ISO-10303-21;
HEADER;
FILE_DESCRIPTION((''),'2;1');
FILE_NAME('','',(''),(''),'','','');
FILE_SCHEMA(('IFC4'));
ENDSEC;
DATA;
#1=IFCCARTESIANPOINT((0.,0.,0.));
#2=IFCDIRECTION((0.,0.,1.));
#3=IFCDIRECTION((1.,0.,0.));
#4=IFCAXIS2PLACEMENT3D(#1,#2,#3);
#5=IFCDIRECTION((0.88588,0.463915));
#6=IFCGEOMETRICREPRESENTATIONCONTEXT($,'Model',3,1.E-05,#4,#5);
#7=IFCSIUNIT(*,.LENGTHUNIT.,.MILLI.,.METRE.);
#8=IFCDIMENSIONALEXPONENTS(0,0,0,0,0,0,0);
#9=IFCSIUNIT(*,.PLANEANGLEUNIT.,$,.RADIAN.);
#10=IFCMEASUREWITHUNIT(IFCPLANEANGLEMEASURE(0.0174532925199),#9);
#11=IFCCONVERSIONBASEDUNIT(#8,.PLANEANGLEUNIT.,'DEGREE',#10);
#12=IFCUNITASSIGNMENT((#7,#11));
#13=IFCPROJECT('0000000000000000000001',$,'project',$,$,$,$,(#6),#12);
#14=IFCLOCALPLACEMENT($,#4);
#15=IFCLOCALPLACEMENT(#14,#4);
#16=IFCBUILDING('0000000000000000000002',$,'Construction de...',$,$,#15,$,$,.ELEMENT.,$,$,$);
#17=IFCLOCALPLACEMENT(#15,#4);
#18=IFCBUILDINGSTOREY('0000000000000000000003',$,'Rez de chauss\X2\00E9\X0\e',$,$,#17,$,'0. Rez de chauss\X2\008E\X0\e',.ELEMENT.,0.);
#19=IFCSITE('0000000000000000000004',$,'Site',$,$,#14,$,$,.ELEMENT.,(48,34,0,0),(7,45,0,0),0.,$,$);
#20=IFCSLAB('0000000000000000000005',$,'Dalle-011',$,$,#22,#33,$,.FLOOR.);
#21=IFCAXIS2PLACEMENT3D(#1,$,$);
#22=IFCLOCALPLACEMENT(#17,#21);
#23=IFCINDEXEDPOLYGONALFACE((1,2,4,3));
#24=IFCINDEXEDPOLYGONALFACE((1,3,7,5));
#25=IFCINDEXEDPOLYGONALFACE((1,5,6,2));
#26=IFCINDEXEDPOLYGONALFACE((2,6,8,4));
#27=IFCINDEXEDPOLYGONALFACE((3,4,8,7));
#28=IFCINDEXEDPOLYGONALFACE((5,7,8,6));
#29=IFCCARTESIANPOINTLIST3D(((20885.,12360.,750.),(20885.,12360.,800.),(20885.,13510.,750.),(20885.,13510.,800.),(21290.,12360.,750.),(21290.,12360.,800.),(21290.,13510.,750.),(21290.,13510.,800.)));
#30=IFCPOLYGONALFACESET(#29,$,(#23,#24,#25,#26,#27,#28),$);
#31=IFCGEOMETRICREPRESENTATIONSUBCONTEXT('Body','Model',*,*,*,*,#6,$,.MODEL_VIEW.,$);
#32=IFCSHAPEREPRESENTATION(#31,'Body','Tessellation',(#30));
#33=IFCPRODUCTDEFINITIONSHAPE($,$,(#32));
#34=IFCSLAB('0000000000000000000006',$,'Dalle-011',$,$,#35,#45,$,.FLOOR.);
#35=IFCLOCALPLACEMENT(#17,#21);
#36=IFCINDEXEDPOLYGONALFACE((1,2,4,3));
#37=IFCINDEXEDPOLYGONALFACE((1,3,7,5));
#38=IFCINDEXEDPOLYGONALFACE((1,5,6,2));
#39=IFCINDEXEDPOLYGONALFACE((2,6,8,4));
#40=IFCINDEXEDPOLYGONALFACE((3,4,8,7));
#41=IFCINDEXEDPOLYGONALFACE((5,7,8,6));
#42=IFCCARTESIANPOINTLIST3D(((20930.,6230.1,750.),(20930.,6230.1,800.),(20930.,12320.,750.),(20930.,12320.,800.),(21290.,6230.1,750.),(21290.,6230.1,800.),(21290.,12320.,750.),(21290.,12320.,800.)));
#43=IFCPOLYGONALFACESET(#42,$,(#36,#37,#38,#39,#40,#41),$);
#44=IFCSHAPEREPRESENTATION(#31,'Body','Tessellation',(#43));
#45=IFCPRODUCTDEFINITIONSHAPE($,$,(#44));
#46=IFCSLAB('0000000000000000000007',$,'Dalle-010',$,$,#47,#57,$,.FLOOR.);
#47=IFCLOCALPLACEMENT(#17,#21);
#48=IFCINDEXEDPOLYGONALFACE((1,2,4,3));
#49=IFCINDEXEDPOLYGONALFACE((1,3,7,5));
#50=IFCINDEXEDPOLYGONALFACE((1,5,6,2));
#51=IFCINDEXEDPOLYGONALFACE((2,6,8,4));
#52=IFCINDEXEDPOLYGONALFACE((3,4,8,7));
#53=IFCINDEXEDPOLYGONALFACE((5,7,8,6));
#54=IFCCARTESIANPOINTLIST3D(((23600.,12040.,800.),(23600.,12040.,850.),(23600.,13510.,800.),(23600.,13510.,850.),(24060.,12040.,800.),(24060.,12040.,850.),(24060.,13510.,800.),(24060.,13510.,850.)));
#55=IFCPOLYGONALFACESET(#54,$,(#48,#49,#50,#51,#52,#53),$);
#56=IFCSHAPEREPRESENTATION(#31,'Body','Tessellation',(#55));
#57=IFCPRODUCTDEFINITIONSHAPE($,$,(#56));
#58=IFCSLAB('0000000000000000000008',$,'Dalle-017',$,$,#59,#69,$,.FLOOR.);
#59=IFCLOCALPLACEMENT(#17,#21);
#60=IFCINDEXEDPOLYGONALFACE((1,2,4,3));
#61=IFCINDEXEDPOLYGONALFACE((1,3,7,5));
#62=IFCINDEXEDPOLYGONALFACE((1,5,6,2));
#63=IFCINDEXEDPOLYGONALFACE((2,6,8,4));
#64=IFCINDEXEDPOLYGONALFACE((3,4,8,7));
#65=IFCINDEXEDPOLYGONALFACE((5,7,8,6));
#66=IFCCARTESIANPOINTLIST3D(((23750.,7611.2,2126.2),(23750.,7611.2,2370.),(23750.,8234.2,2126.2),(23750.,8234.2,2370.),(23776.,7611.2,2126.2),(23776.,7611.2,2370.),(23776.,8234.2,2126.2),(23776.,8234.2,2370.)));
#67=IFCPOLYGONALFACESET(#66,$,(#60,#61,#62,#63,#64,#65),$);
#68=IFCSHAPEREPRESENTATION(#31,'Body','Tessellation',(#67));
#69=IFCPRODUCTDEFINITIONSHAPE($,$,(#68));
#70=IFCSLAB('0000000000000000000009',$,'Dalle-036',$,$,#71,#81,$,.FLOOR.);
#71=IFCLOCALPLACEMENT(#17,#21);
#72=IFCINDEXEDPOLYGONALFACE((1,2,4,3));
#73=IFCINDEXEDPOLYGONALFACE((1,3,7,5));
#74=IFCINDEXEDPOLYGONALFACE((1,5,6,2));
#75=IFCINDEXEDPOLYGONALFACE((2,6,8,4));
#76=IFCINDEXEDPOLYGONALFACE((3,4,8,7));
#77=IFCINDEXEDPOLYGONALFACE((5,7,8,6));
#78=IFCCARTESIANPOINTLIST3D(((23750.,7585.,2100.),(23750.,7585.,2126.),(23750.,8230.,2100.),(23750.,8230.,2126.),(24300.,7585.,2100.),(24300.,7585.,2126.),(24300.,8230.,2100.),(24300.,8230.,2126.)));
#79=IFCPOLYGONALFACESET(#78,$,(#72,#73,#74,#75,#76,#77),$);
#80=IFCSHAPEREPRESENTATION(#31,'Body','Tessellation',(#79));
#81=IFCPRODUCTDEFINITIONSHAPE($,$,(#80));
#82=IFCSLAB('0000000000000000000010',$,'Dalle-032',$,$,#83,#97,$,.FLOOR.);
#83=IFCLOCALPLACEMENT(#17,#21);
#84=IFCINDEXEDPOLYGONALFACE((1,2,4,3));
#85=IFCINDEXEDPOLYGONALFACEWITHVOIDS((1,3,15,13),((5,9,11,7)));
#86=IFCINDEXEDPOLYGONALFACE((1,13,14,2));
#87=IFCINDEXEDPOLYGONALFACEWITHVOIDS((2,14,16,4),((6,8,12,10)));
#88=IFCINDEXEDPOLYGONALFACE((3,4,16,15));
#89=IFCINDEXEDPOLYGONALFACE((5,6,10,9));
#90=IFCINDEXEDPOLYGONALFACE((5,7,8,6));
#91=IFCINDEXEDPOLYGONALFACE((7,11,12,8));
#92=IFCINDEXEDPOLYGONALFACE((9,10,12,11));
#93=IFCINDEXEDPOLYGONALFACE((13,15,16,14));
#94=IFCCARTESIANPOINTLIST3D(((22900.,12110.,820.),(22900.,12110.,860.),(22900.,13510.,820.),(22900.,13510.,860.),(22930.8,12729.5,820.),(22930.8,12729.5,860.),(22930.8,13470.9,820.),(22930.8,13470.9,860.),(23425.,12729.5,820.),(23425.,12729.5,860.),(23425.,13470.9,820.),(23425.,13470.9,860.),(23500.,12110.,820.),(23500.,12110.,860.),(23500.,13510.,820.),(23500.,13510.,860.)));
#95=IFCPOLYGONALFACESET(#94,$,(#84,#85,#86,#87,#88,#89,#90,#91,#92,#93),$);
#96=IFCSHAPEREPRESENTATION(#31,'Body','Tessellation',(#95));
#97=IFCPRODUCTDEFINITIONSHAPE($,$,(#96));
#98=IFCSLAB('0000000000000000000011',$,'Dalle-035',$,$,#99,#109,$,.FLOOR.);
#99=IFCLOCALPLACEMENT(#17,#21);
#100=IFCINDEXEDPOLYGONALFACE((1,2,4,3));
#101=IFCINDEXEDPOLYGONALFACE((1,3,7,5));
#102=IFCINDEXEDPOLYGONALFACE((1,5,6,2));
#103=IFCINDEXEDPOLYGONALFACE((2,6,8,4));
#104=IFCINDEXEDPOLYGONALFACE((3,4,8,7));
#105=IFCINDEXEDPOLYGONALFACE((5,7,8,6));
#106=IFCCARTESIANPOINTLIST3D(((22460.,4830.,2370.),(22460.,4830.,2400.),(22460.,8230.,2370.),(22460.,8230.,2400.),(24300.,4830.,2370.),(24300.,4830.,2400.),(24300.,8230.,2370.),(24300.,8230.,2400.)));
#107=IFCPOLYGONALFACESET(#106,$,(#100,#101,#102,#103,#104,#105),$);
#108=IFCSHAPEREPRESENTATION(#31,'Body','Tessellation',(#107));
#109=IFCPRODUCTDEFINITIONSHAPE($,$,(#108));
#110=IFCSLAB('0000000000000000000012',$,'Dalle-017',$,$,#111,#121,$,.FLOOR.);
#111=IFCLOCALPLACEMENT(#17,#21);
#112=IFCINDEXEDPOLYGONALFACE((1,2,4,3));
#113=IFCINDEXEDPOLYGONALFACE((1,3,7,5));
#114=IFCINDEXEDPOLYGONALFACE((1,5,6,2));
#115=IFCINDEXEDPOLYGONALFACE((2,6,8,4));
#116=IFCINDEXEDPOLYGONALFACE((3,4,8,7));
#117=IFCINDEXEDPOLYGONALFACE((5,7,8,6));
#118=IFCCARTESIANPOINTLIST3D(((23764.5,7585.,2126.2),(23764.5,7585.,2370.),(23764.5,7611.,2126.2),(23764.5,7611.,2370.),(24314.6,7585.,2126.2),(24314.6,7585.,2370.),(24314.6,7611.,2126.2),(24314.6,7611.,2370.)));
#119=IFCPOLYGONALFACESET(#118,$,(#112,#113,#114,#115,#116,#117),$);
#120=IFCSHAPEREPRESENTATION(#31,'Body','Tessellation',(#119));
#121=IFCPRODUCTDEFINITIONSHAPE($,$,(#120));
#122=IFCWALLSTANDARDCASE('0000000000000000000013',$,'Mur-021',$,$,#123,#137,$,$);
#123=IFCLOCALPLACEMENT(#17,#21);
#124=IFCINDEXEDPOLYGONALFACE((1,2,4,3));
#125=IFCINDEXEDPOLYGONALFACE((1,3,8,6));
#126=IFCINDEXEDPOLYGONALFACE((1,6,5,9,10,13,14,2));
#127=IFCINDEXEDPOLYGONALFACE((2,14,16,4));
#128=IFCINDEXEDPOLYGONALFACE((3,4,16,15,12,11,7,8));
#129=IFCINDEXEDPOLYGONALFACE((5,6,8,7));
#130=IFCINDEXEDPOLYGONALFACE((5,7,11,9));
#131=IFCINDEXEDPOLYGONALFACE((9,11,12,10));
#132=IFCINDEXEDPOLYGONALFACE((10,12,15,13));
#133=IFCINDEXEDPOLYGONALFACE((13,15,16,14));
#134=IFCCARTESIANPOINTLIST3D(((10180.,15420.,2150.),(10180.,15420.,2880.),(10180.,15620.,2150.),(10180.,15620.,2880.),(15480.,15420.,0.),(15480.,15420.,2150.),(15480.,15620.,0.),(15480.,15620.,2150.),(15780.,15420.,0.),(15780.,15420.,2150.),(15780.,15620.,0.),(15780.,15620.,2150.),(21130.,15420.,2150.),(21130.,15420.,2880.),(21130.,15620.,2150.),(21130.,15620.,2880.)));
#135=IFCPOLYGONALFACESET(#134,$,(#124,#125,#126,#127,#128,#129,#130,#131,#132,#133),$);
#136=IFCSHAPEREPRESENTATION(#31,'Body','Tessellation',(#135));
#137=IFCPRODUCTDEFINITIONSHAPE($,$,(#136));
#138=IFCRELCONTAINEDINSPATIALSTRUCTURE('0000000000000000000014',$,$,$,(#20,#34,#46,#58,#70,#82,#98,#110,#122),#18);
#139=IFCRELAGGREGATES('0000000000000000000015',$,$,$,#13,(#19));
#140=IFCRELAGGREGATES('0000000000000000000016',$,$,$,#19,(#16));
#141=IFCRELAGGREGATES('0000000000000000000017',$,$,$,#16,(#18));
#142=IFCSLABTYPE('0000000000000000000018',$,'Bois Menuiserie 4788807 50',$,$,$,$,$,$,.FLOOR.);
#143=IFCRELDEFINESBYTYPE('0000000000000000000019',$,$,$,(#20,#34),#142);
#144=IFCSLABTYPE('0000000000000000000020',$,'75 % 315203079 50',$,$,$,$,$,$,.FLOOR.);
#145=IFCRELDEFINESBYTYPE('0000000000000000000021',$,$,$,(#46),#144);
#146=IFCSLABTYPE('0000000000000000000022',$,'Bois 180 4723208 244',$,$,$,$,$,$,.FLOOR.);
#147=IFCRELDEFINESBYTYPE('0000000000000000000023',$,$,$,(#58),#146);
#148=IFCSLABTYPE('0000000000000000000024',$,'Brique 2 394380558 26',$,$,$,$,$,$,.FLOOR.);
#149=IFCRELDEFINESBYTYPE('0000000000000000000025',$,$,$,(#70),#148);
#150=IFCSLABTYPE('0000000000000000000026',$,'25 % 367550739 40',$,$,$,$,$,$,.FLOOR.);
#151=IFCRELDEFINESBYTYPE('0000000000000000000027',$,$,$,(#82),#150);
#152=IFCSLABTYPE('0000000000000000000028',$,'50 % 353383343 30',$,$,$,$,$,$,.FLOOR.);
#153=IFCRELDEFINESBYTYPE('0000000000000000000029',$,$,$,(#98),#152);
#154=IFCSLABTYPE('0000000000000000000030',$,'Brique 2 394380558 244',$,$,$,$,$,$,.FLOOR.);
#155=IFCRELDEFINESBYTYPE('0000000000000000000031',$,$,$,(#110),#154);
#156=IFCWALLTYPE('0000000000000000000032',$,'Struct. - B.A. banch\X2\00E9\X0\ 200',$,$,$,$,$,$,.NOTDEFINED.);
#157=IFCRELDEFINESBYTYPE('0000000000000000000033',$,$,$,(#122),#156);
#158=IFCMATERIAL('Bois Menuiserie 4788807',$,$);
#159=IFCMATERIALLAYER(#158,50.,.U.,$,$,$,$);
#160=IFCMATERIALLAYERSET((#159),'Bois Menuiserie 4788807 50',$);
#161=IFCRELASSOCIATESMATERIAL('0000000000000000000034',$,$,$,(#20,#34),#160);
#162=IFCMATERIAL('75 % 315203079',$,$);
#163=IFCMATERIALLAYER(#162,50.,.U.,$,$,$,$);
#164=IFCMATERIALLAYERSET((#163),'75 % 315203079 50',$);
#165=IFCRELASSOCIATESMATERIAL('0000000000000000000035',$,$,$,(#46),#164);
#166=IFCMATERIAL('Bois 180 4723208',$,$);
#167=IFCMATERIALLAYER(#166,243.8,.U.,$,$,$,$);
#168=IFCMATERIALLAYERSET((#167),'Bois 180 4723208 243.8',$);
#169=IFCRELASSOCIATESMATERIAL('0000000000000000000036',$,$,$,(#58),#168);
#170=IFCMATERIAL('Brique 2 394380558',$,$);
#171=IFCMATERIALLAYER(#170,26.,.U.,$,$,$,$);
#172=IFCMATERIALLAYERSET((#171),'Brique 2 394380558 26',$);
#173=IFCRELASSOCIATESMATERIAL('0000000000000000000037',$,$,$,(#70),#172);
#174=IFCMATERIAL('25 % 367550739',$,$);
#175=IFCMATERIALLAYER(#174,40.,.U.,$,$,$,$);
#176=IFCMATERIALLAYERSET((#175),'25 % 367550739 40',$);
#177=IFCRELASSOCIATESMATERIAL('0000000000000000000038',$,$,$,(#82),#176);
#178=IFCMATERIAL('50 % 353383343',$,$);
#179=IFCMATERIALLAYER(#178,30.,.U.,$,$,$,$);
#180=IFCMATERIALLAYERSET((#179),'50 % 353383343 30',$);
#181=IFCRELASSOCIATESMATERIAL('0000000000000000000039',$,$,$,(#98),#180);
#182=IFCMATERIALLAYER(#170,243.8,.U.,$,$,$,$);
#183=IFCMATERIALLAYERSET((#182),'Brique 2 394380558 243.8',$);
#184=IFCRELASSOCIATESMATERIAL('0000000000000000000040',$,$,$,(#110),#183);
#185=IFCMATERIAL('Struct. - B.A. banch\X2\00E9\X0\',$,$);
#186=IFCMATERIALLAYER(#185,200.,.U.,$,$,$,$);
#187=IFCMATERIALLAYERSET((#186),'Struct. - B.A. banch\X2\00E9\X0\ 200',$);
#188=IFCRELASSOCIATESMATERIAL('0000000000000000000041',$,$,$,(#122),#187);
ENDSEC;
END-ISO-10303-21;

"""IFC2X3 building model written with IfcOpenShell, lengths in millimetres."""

from ifc_helpers import new_model, entity, si_unit, converted_unit, direction, frame, origin_with_axes, origin_2d_with_axis, place, context, subcontext, project, spatial, polyline, rectangle, outline, extrude, material, layer, layer_set, layer_usage, type_object, element, save


model = new_model("IFC2X3")

# Units and contexts
model_context = context("Model", 3, precision=1e-05, world=origin_with_axes(), true_north=direction((0.88588, 0.463915)))
body_context = subcontext(model_context, "Body", "Model", "MODEL_VIEW")
ifc_project = project(units=[si_unit("LENGTHUNIT", "METRE", prefix="MILLI"), converted_unit("PLANEANGLEUNIT", "DEGREE", entity("IfcPlaneAngleMeasure", 0.0174532925199), si_unit("PLANEANGLEUNIT", "RADIAN"), dimensions=[0, 0, 0, 0, 0, 0, 0])], contexts=[model_context])

# Site, building, storey
site_placement = place(None, origin_with_axes())
site = spatial("IfcSite", under=ifc_project, at=site_placement, Name="Site", CompositionType="ELEMENT", RefLatitude=(48, 34, 0, 0), RefLongitude=(7, 45, 0, 0), RefElevation=0.0)
building_placement = place(site_placement, origin_with_axes())
building = spatial("IfcBuilding", under=site, at=building_placement, Name="Construction de...", CompositionType="ELEMENT")
storey_placement = place(building_placement, origin_with_axes())
storey = spatial("IfcBuildingStorey", under=building, at=storey_placement, Name="Rez de chaussée", LongName="0. Rez de chauss\u008ee", CompositionType="ELEMENT", Elevation=0.0)

# Slabs
ifc_material_1 = material(Name="Bois Menuiserie 4788807")
ifc_layer_1 = layer(ifc_material_1, 50.0, ventilated="UNKNOWN")
ifc_layer_set_1 = layer_set([ifc_layer_1], Name="Bois Menuiserie 4788807 50")
ifc_layer_usage_1 = layer_usage(ifc_layer_set_1, "AXIS3", "NEGATIVE", 50.0)
slab_type_1 = type_object("IfcSlabType", Name="Bois Menuiserie 4788807 50", PredefinedType="FLOOR")
slab_1_placement = place(storey_placement, frame((21290.0, 12360.0, 800.0), z_axis=(0.0, 0.0, 1.0), x_axis=(1.0, 0.0, 0.0)))
element("IfcSlab", 1, at=slab_1_placement, inside=storey, type_object=slab_type_1, material=ifc_layer_usage_1, Name="Dalle-011", PredefinedType="FLOOR", context=body_context, shape_type="SweptSolid", body=[
    extrude(outline(polyline([(0.0, 0.0), (0.0, 1150.0), (-405.0, 1150.0), (-405.0, 0.0), (0.0, 0.0)])), frame((0.0, 0.0, -50.0), z_axis=(0.0, 0.0, 1.0), x_axis=(1.0, 0.0, 0.0)), (0.0, 0.0, 1.0), 50.0),
])
ifc_layer_usage_2 = layer_usage(ifc_layer_set_1, "AXIS3", "NEGATIVE", 50.0)
slab_2_placement = place(storey_placement, frame((21290.0, 6230.1, 800.0), z_axis=(0.0, 0.0, 1.0), x_axis=(1.0, 0.0, 0.0)))
element("IfcSlab", 2, at=slab_2_placement, inside=storey, type_object=slab_type_1, material=ifc_layer_usage_2, Name="Dalle-011", PredefinedType="FLOOR", context=body_context, shape_type="SweptSolid", body=[
    extrude(outline(polyline([(0.0, 0.0), (0.0, 6089.9), (-360.0, 6089.9), (-360.0, 0.0), (0.0, 0.0)])), frame((0.0, 0.0, -50.0), z_axis=(0.0, 0.0, 1.0), x_axis=(1.0, 0.0, 0.0)), (0.0, 0.0, 1.0), 50.0),
])
ifc_material_2 = material(Name="75 % 315203079")
ifc_layer_2 = layer(ifc_material_2, 50.0, ventilated="UNKNOWN")
ifc_layer_set_2 = layer_set([ifc_layer_2], Name="75 % 315203079 50")
ifc_layer_usage_3 = layer_usage(ifc_layer_set_2, "AXIS3", "NEGATIVE", 50.0)
slab_type_2 = type_object("IfcSlabType", Name="75 % 315203079 50", PredefinedType="FLOOR")
slab_3_placement = place(storey_placement, frame((24060.0, 12040.0, 850.0), z_axis=(0.0, 0.0, 1.0), x_axis=(1.0, 0.0, 0.0)))
element("IfcSlab", 3, at=slab_3_placement, inside=storey, type_object=slab_type_2, material=ifc_layer_usage_3, Name="Dalle-010", PredefinedType="FLOOR", context=body_context, shape_type="SweptSolid", body=[
    extrude(outline(polyline([(0.0, 0.0), (0.0, 1470.0), (-460.0, 1470.0), (-460.0, 0.0), (0.0, 0.0)])), frame((0.0, 0.0, -50.0), z_axis=(0.0, 0.0, 1.0), x_axis=(1.0, 0.0, 0.0)), (0.0, 0.0, 1.0), 50.0),
])
ifc_material_3 = material(Name="Bois 180 4723208")
ifc_layer_3 = layer(ifc_material_3, 243.8, ventilated="UNKNOWN")
ifc_layer_set_3 = layer_set([ifc_layer_3], Name="Bois 180 4723208 243.8")
ifc_layer_usage_4 = layer_usage(ifc_layer_set_3, "AXIS3", "NEGATIVE", 243.8)
slab_type_3 = type_object("IfcSlabType", Name="Bois 180 4723208 244", PredefinedType="FLOOR")
slab_4_placement = place(storey_placement, frame((23776.0, 8234.2, 2370.0), z_axis=(0.0, 0.0, 1.0), x_axis=(1.0, 0.0, 0.0)))
element("IfcSlab", 4, at=slab_4_placement, inside=storey, type_object=slab_type_3, material=ifc_layer_usage_4, Name="Dalle-017", PredefinedType="FLOOR", context=body_context, shape_type="SweptSolid", body=[
    extrude(outline(polyline([(0.0, 0.0), (-26.0, 0.0), (-26.0, -623.0), (0.0, -623.0), (0.0, 0.0)])), frame((0.0, 0.0, -243.8), z_axis=(0.0, 0.0, 1.0), x_axis=(1.0, 0.0, 0.0)), (0.0, 0.0, 1.0), 243.8),
])
ifc_material_4 = material(Name="Brique 2 394380558")
ifc_layer_4 = layer(ifc_material_4, 26.0, ventilated="UNKNOWN")
ifc_layer_set_4 = layer_set([ifc_layer_4], Name="Brique 2 394380558 26")
ifc_layer_usage_5 = layer_usage(ifc_layer_set_4, "AXIS3", "NEGATIVE", 26.0)
slab_type_4 = type_object("IfcSlabType", Name="Brique 2 394380558 26", PredefinedType="FLOOR")
slab_5_placement = place(storey_placement, frame((24300.0, 8230.0, 2126.0), z_axis=(0.0, 0.0, 1.0), x_axis=(1.0, 0.0, 0.0)))
element("IfcSlab", 5, at=slab_5_placement, inside=storey, type_object=slab_type_4, material=ifc_layer_usage_5, Name="Dalle-036", PredefinedType="FLOOR", context=body_context, shape_type="SweptSolid", body=[
    extrude(outline(polyline([(0.0, 0.0), (-550.0, 0.0), (-550.0, -645.0), (0.0, -645.0), (0.0, 0.0)])), frame((0.0, 0.0, -26.0), z_axis=(0.0, 0.0, 1.0), x_axis=(1.0, 0.0, 0.0)), (0.0, 0.0, 1.0), 26.0),
])

# Slab, opening
ifc_material_5 = material(Name="25 % 367550739")
ifc_layer_5 = layer(ifc_material_5, 40.0, ventilated="UNKNOWN")
ifc_layer_set_5 = layer_set([ifc_layer_5], Name="25 % 367550739 40")
ifc_layer_usage_6 = layer_usage(ifc_layer_set_5, "AXIS3", "NEGATIVE", 40.0)
slab_type_5 = type_object("IfcSlabType", Name="25 % 367550739 40", PredefinedType="FLOOR")
slab_6_placement = place(storey_placement, frame((23500.0, 13510.0, 860.0), z_axis=(0.0, 0.0, 1.0), x_axis=(1.0, 0.0, 0.0)))
slab_6 = element("IfcSlab", 6, at=slab_6_placement, inside=storey, type_object=slab_type_5, material=ifc_layer_usage_6, Name="Dalle-032", PredefinedType="FLOOR", context=body_context, shape_type="SweptSolid", body=[
    extrude(outline(polyline([(0.0, 0.0), (-600.0, 0.0), (-600.0, -1400.0), (0.0, -1400.0), (0.0, 0.0)])), frame((0.0, 0.0, -40.0), z_axis=(0.0, 0.0, 1.0), x_axis=(1.0, 0.0, 0.0)), (0.0, 0.0, 1.0), 40.0),
])
opening_1_placement = place(slab_6_placement, origin_with_axes())
element("IfcOpeningElement", 7, at=opening_1_placement, cuts=slab_6, context=body_context, shape_type="SweptSolid", body=[
    extrude(outline(polyline([(-75.0, -39.1), (-569.2, -39.1), (-569.2, -780.5), (-75.0, -780.5), (-75.0, -39.1)])), frame((0.0, 0.0, -40.0), z_axis=(0.0, 0.0, 1.0), x_axis=(1.0, 0.0, 0.0)), (0.0, 0.0, 1.0), 40.0),
])

# Slabs
ifc_material_6 = material(Name="50 % 353383343")
ifc_layer_6 = layer(ifc_material_6, 30.0, ventilated="UNKNOWN")
ifc_layer_set_6 = layer_set([ifc_layer_6], Name="50 % 353383343 30")
ifc_layer_usage_7 = layer_usage(ifc_layer_set_6, "AXIS3", "NEGATIVE", 30.0)
slab_type_6 = type_object("IfcSlabType", Name="50 % 353383343 30", PredefinedType="FLOOR")
slab_7_placement = place(storey_placement, frame((22460.0, 8230.0, 2400.0), z_axis=(0.0, 0.0, 1.0), x_axis=(1.0, 0.0, 0.0)))
element("IfcSlab", 8, at=slab_7_placement, inside=storey, type_object=slab_type_6, material=ifc_layer_usage_7, Name="Dalle-035", PredefinedType="FLOOR", context=body_context, shape_type="SweptSolid", body=[
    extrude(outline(polyline([(0.0, 0.0), (0.0, -3400.0), (1840.0, -3400.0), (1840.0, 0.0), (0.0, 0.0)])), frame((0.0, 0.0, -30.0), z_axis=(0.0, 0.0, 1.0), x_axis=(1.0, 0.0, 0.0)), (0.0, 0.0, 1.0), 30.0),
])
ifc_layer_7 = layer(ifc_material_4, 243.8, ventilated="UNKNOWN")
ifc_layer_set_7 = layer_set([ifc_layer_7], Name="Brique 2 394380558 243.8")
ifc_layer_usage_8 = layer_usage(ifc_layer_set_7, "AXIS3", "NEGATIVE", 243.8)
slab_type_7 = type_object("IfcSlabType", Name="Brique 2 394380558 244", PredefinedType="FLOOR")
slab_8_placement = place(storey_placement, frame((23764.5, 7585.0, 2370.0), z_axis=(0.0, 0.0, 1.0), x_axis=(1.0, 0.0, 0.0)))
element("IfcSlab", 9, at=slab_8_placement, inside=storey, type_object=slab_type_7, material=ifc_layer_usage_8, Name="Dalle-017", PredefinedType="FLOOR", context=body_context, shape_type="SweptSolid", body=[
    extrude(outline(polyline([(0.0, 0.0), (550.1, 0.0), (550.1, 26.0), (0.0, 26.0), (0.0, 0.0)])), frame((0.0, 0.0, -243.8), z_axis=(0.0, 0.0, 1.0), x_axis=(1.0, 0.0, 0.0)), (0.0, 0.0, 1.0), 243.8),
])

# Wall, openings
ifc_material_7 = material(Name="Struct. - B.A. banché")
ifc_layer_8 = layer(ifc_material_7, 200.0, ventilated="UNKNOWN")
ifc_layer_set_8 = layer_set([ifc_layer_8], Name="Struct. - B.A. banché 200")
ifc_layer_usage_9 = layer_usage(ifc_layer_set_8, "AXIS2", "POSITIVE", -100.0)
wall_type_1 = type_object("IfcWallType", Name="Struct. - B.A. banché 200", PredefinedType="NOTDEFINED")
wall_1_placement = place(storey_placement, frame((21130.0, 15520.0, 0.0), z_axis=(0.0, 0.0, 1.0), x_axis=(-1.0, 0.0, 0.0)))
wall_1 = element("IfcWallStandardCase", 10, at=wall_1_placement, inside=storey, type_object=wall_type_1, material=ifc_layer_usage_9, Name="Mur-021", context=body_context, shape_type="SweptSolid", body=[
    extrude(outline(polyline([(0.0, -100.0), (10950.0, -100.0), (10950.0, 100.0), (0.0, 100.0), (0.0, -100.0)])), origin_with_axes(), (0.0, 0.0, 1.0), 2880.0),
])
opening_2_placement = place(wall_1_placement, frame((8325.0, 0.0, 0.0), z_axis=(0.0, 0.0, 1.0), x_axis=(1.0, 0.0, 0.0)))
element("IfcOpeningElement", 11, at=opening_2_placement, cuts=wall_1, context=body_context, shape_type="SweptSolid", body=[
    extrude(rectangle(XDim=5350.0, YDim=2150.0, at=origin_2d_with_axis()), frame((0.0, -100.0, 1075.0), z_axis=(0.0, 1.0, 0.0), x_axis=(1.0, 0.0, 0.0)), (0.0, 0.0, -1.0), 200.0),
    extrude(rectangle(XDim=5350.0, YDim=2150.0, at=origin_2d_with_axis()), frame((0.0, -100.0, 1075.0), z_axis=(0.0, -1.0, 0.0), x_axis=(1.0, 0.0, 0.0)), (0.0, 0.0, -1.0), 200.0),
])
opening_3_placement = place(wall_1_placement, frame((2675.0, 0.0, 0.0), z_axis=(0.0, 0.0, 1.0), x_axis=(1.0, 0.0, 0.0)))
element("IfcOpeningElement", 12, at=opening_3_placement, cuts=wall_1, context=body_context, shape_type="SweptSolid", body=[
    extrude(rectangle(XDim=5350.0, YDim=2150.0, at=origin_2d_with_axis()), frame((0.0, -100.0, 1075.0), z_axis=(0.0, 1.0, 0.0), x_axis=(1.0, 0.0, 0.0)), (0.0, 0.0, -1.0), 200.0),
    extrude(rectangle(XDim=5350.0, YDim=2150.0, at=origin_2d_with_axis()), frame((0.0, -100.0, 1075.0), z_axis=(0.0, -1.0, 0.0), x_axis=(1.0, 0.0, 0.0)), (0.0, 0.0, -1.0), 200.0),
])

save(model, "model.ifc")
